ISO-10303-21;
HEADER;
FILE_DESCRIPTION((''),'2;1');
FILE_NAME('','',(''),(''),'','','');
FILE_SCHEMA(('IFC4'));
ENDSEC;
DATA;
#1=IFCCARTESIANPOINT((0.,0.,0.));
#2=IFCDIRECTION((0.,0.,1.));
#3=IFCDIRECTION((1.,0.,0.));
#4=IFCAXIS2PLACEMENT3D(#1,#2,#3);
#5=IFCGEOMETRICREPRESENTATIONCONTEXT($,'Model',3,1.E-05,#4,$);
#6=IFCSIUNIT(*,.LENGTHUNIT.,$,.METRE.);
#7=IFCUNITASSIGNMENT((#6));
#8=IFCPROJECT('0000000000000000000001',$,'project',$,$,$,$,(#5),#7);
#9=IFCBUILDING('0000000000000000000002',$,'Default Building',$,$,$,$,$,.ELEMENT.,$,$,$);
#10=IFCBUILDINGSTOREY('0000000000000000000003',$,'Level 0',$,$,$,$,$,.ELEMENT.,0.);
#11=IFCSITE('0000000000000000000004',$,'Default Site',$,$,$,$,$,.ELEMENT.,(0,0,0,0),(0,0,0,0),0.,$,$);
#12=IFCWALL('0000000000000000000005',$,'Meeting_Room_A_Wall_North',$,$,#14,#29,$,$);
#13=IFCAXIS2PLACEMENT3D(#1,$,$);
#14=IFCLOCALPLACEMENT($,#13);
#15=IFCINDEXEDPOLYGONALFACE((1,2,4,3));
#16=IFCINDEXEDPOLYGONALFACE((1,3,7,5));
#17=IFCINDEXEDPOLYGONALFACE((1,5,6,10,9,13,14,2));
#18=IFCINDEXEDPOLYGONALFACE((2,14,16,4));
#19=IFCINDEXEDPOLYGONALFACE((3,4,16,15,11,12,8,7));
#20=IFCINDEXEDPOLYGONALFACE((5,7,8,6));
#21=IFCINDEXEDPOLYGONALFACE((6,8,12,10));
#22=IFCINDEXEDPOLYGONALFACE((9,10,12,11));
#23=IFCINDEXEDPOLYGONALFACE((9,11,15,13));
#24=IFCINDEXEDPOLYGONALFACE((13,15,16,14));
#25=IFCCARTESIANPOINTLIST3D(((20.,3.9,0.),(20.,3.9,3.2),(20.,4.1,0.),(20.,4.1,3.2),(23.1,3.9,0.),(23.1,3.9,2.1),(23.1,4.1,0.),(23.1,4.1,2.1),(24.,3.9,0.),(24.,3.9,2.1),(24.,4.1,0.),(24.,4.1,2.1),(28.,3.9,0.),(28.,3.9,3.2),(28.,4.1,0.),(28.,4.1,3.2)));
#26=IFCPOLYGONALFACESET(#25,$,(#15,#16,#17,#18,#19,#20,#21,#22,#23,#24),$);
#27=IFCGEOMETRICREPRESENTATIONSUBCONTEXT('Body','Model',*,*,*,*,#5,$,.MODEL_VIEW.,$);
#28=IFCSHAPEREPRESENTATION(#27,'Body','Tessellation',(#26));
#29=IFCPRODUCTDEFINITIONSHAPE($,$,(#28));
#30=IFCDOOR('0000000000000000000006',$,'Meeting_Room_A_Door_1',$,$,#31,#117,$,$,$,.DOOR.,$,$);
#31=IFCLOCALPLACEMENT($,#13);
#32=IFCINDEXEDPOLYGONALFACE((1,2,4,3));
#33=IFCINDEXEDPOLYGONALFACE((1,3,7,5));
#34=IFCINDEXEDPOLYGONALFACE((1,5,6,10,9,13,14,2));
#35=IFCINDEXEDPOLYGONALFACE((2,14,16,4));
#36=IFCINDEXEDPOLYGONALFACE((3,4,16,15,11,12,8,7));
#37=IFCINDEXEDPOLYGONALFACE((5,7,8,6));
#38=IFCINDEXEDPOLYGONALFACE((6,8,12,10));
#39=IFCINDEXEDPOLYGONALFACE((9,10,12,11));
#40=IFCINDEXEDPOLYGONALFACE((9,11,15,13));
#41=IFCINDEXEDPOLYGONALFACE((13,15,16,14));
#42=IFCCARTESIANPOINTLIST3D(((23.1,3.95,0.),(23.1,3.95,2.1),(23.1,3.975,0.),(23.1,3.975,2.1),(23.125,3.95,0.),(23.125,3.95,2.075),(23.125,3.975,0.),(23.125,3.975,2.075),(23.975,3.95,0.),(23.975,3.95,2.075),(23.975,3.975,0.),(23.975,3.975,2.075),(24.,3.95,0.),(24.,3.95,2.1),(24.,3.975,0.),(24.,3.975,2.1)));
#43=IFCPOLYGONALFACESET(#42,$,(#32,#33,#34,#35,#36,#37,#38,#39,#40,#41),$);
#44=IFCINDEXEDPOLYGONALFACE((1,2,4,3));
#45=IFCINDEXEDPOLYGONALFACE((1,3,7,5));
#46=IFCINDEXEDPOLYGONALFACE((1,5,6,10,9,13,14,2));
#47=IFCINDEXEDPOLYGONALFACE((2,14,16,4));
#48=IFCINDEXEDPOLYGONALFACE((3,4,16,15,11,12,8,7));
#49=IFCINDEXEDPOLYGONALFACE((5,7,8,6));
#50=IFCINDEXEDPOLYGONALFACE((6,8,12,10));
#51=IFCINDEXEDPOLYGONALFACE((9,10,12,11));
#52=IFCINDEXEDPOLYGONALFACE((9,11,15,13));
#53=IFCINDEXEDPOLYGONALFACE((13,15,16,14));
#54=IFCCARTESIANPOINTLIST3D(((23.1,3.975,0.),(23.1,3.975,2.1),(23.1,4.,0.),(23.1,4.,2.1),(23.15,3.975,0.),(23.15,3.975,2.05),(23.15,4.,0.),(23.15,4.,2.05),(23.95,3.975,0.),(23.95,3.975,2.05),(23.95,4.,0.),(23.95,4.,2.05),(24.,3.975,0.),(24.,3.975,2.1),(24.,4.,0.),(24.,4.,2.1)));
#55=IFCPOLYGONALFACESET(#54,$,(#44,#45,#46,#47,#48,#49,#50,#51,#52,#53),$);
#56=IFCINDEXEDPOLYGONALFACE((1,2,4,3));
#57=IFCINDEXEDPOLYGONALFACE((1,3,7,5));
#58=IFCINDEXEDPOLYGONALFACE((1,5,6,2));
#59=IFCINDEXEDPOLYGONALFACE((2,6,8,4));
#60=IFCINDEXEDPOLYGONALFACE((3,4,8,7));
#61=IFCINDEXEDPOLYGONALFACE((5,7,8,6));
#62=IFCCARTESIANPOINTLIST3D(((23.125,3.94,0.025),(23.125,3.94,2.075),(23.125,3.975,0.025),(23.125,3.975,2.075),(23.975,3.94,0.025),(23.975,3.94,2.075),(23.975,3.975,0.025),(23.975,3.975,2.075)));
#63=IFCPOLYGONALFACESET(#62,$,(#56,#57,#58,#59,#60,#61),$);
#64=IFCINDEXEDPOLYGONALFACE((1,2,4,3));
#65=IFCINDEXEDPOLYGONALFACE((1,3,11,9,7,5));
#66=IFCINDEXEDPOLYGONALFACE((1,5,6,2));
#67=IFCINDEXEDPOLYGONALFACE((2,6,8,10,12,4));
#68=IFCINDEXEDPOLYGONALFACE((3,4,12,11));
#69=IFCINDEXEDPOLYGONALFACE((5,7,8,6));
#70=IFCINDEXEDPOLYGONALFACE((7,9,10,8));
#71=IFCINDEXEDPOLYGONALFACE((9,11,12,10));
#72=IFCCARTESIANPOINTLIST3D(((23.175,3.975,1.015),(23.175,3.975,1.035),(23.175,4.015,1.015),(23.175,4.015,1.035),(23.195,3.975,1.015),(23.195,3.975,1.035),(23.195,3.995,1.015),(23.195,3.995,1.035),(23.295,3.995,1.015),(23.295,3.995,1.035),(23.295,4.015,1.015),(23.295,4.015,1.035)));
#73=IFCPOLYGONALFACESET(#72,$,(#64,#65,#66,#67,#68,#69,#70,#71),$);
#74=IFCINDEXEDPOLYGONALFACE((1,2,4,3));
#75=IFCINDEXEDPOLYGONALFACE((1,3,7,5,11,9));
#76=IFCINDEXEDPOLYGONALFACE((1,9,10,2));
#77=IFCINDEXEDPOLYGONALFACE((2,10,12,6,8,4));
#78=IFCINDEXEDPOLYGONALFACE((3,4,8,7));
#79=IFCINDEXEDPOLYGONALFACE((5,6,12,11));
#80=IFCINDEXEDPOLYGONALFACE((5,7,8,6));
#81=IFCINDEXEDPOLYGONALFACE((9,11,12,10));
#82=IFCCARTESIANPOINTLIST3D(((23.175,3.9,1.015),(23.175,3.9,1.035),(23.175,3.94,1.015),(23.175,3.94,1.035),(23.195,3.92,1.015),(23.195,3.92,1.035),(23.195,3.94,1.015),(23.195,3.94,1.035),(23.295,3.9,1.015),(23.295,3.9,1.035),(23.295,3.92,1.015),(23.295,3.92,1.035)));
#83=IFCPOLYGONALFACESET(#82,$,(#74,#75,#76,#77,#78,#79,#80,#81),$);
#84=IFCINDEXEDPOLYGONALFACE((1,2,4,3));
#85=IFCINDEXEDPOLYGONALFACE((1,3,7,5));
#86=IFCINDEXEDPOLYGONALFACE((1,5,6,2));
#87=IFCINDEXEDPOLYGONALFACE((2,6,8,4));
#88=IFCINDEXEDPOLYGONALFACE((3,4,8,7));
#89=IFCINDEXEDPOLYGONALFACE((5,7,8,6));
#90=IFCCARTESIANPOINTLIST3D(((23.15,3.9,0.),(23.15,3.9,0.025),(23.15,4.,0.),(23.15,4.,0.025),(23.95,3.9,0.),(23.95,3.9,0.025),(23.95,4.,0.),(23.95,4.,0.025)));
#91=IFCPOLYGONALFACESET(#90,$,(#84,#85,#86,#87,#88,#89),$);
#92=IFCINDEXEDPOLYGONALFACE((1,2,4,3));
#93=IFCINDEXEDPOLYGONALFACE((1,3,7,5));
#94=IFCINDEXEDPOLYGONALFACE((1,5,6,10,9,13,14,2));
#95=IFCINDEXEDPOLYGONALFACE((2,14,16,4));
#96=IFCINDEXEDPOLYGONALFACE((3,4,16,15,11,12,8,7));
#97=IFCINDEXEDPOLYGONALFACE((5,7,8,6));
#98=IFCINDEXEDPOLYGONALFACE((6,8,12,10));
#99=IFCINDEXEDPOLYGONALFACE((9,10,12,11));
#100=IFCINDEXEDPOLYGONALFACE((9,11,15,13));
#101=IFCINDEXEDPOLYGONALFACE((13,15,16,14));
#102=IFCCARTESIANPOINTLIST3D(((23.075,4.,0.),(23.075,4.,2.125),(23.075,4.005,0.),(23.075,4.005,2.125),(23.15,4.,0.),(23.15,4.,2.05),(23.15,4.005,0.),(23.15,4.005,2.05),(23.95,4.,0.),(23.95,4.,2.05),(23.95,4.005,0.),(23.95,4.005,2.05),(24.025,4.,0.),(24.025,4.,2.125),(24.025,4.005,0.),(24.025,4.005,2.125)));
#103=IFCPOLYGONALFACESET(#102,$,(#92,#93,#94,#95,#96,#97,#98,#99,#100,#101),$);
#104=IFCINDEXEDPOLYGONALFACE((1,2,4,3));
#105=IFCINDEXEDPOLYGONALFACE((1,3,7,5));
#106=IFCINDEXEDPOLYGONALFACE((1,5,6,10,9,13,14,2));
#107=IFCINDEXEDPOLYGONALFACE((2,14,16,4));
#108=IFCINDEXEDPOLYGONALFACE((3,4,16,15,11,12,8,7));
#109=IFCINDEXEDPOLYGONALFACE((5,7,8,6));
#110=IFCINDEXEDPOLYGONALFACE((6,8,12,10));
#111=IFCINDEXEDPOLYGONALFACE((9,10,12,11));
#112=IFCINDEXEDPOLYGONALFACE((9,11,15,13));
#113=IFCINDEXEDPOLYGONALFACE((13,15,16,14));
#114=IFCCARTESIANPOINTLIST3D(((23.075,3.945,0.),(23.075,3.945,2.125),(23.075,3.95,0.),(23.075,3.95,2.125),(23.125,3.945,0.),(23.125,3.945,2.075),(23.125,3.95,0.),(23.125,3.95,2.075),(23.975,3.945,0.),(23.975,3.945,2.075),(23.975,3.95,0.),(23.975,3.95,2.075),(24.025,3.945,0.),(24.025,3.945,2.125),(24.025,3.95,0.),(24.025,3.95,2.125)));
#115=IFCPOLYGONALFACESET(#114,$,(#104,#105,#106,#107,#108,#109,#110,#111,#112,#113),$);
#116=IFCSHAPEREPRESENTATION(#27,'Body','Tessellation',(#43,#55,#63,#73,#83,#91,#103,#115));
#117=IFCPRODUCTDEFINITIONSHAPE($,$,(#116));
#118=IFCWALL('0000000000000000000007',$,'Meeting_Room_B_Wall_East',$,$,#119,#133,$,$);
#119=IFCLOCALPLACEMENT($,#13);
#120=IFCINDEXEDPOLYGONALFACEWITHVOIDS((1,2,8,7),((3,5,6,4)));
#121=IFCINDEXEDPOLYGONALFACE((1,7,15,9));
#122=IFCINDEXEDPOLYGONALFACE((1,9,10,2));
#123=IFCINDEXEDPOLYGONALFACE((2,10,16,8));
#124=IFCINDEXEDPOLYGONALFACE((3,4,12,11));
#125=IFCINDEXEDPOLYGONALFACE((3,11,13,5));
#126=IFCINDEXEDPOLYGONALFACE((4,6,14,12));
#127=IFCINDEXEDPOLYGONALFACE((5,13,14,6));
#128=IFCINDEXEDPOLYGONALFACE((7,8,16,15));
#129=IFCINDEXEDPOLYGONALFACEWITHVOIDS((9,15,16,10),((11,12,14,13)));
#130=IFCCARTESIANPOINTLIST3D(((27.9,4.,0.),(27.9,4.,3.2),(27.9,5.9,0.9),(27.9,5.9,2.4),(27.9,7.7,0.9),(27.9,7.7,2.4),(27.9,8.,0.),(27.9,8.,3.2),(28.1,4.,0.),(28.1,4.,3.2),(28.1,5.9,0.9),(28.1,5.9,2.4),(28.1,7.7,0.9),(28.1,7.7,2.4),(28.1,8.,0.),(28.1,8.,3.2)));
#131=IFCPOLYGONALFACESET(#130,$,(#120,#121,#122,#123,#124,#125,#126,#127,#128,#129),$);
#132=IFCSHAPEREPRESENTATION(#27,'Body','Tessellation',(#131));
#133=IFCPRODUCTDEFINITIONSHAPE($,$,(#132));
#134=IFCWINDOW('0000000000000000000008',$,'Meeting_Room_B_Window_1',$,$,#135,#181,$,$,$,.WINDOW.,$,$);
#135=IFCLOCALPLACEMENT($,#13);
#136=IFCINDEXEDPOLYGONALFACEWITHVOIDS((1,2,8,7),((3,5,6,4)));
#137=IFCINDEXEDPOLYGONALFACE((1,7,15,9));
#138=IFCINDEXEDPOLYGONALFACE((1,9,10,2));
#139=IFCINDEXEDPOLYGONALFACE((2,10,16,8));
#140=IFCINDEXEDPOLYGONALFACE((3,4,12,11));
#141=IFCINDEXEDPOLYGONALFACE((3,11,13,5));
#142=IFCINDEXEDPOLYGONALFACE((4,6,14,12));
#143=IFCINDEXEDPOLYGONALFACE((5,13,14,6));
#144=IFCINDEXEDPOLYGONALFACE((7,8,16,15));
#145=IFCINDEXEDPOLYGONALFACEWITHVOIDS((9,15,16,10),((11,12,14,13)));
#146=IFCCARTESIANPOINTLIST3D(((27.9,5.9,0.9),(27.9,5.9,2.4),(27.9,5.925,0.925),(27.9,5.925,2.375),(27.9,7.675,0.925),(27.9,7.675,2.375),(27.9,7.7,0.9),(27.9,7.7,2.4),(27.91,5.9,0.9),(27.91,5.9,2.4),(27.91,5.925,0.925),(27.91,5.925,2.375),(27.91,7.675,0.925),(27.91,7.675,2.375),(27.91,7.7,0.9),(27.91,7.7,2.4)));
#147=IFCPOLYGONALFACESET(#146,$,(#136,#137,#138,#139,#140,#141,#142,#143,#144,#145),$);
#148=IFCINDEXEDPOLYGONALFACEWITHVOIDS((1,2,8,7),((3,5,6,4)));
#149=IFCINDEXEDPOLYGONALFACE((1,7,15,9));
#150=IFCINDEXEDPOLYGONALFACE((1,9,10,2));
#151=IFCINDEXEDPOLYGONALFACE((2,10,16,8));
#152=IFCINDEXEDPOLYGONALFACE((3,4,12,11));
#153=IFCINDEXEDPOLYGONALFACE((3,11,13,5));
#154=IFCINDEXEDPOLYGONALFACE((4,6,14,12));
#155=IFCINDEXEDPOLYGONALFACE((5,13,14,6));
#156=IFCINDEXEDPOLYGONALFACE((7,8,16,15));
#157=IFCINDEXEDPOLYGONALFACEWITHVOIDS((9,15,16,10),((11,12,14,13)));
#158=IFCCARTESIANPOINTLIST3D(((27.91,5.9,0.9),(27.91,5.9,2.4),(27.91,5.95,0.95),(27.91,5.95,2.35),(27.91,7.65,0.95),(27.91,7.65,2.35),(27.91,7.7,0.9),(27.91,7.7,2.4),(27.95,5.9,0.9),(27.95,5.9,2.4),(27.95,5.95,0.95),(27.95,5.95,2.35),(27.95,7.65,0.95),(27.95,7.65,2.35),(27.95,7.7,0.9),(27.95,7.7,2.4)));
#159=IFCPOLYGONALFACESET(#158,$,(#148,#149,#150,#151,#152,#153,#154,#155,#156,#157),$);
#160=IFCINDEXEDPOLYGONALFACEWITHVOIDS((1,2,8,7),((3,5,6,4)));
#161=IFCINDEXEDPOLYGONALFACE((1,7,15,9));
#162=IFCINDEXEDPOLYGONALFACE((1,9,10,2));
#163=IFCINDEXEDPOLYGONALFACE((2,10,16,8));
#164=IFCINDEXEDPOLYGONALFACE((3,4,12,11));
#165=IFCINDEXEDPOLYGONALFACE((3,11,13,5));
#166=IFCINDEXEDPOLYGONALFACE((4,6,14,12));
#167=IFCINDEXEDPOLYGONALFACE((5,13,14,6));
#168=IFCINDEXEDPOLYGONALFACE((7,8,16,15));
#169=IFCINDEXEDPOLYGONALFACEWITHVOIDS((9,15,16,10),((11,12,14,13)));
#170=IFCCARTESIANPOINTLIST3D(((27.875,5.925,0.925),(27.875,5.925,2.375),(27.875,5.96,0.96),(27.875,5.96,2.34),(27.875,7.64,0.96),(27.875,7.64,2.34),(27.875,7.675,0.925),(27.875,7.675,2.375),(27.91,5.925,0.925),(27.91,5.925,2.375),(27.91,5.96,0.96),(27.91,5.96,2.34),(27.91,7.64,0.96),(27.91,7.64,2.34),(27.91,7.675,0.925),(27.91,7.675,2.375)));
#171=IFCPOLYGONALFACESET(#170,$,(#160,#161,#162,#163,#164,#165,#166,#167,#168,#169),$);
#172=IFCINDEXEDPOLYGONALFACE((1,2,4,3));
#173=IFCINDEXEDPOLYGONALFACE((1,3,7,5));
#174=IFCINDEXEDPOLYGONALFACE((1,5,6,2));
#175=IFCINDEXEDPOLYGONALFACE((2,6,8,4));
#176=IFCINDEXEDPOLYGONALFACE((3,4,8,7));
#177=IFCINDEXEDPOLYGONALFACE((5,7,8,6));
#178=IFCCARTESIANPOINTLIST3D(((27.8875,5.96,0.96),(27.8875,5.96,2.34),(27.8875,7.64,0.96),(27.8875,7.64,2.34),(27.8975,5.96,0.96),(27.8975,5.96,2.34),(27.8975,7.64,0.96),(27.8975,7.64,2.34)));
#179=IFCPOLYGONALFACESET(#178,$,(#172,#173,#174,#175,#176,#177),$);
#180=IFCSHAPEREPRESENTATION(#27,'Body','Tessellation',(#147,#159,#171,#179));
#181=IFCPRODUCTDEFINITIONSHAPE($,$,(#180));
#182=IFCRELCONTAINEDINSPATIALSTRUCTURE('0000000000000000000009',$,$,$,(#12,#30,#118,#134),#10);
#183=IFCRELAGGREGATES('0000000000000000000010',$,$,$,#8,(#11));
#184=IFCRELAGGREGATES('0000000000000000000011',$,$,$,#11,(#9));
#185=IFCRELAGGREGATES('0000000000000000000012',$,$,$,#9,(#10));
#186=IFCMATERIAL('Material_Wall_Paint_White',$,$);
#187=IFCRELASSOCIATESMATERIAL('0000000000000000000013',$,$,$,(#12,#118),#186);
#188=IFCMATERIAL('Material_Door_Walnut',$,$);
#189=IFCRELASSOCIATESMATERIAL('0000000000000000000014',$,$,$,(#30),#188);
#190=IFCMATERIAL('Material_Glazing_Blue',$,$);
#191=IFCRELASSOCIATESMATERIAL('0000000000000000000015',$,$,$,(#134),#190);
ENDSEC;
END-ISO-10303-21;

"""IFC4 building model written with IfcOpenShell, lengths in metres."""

from ifc_helpers import new_model, si_unit, frame, origin_with_axes, place, context, subcontext, project, spatial, line, indexed_curve, outline, extrude, material, element, fill, save


model = new_model("IFC4")

# Units and contexts
model_context = context("Model", 3, precision=1e-05, world=origin_with_axes())
body_context = subcontext(model_context, "Body", "Model", "MODEL_VIEW")
ifc_project = project(units=[si_unit("LENGTHUNIT", "METRE")], contexts=[model_context])

# Site, building, storey
site = spatial("IfcSite", under=ifc_project, Name="Default Site", CompositionType="ELEMENT", RefLatitude=(0, 0, 0, 0), RefLongitude=(0, 0, 0, 0), RefElevation=0.0)
building = spatial("IfcBuilding", under=site, Name="Default Building", CompositionType="ELEMENT")
storey = spatial("IfcBuildingStorey", under=building, Name="Level 0", CompositionType="ELEMENT", Elevation=0.0)

# Shared definitions
ifc_material_1 = material(Name="Material_Wall_Paint_White")
ifc_material_2 = material(Name="Material_Glazing_Blue")

# Wall, opening, door
wall_1_placement = place(None, frame((28.0, 4.0, 0.0), z_axis=(0.0, 0.0, 1.0), x_axis=(-1.0, 0.0, 0.0)))
wall_1 = element("IfcWall", 1, at=wall_1_placement, inside=storey, material=ifc_material_1, Name="Meeting_Room_A_Wall_North", context=body_context, shape_type="SweptSolid", body=[
    extrude(outline(indexed_curve([(0.0, 0.0), (0.0, 0.2), (8.0, 0.2), (8.0, 0.0), (0.0, 0.0)], self_intersect=False)), frame((0.0, -0.1, 0.0), z_axis=(0.0, 0.0, 1.0), x_axis=(1.0, 0.0, 0.0)), (0.0, 0.0, 1.0), 3.2),
])
opening_1_placement = place(wall_1_placement, frame((4.0, -0.5, 0.0), z_axis=(0.0, 0.0, 1.0), x_axis=(1.0, 0.0, 0.0)))
opening_1 = element("IfcOpeningElement", 2, at=opening_1_placement, inside=storey, cuts=wall_1, PredefinedType="OPENING", context=body_context, shape_type="SweptSolid", body=[
    extrude(outline(indexed_curve([(0.0, 0.0), (0.0, 1.0), (0.9, 1.0), (0.9, 0.0), (0.0, 0.0)], self_intersect=False)), origin_with_axes(), (0.0, 0.0, 1.0), 2.1),
])
ifc_material_3 = material(Name="Material_Door_Walnut")
door_1_placement = place(None, frame((24.0, 4.0, 0.0), z_axis=(0.0, 0.0, 1.0), x_axis=(-1.0, 0.0, 0.0)))
door_1 = element("IfcDoor", 3, at=door_1_placement, inside=storey, material=ifc_material_3, Name="Meeting_Room_A_Door_1", PredefinedType="DOOR", context=body_context, shape_type="SweptSolid", body=[
    extrude(outline(indexed_curve([(0.0, 0.0), (0.0, 2.1), (0.9, 2.1), (0.9, 0.0), (0.875, 0.0), (0.875, 2.075), (0.025, 2.075), (0.025, 0.0)], segments=[line(1, 2, 3, 4, 5, 6, 7, 8, 1)])), frame((0.0, 0.025, 0.0), z_axis=(0.0, -1.0, 0.0), x_axis=(1.0, 0.0, 0.0)), (0.0, 0.0, -1.0), 0.025),
    extrude(outline(indexed_curve([(0.0, 0.0), (0.0, 2.1), (0.9, 2.1), (0.9, 0.0), (0.85, 0.0), (0.85, 2.05), (0.05, 2.05), (0.05, 0.0)], segments=[line(1, 2, 3, 4, 5, 6, 7, 8, 1)])), frame((0.0, 0.0, 0.0), z_axis=(0.0, -1.0, 0.0), x_axis=(1.0, 0.0, 0.0)), (0.0, 0.0, -1.0), 0.025),
    extrude(outline(indexed_curve([(0.0, 0.0), (0.85, 0.0), (0.85, 0.035), (0.0, 0.035)], segments=[line(1, 2, 3, 4, 1)])), frame((0.025, 0.025, 0.025), z_axis=(0.0, 0.0, 1.0), x_axis=(1.0, 0.0, 0.0)), (0.0, 0.0, 1.0), 2.05),
    extrude(outline(indexed_curve([(0.0, 0.0), (0.0, -0.04), (-0.12, -0.04), (-0.12, -0.02), (-0.02, -0.02), (-0.02, 0.0)], segments=[line(1, 2, 3, 4, 5, 6, 1)])), frame((0.825, 0.025, 1.015), z_axis=(0.0, 0.0, 1.0), x_axis=(1.0, 0.0, 0.0)), (0.0, 0.0, 1.0), 0.02),
    extrude(outline(indexed_curve([(0.0, 0.0), (0.0, 0.04), (-0.12, 0.04), (-0.12, 0.02), (-0.02, 0.02), (-0.02, 0.0)], segments=[line(1, 2, 3, 4, 5, 6, 1)])), frame((0.825, 0.06, 1.015), z_axis=(0.0, 0.0, 1.0), x_axis=(1.0, 0.0, 0.0)), (0.0, 0.0, 1.0), 0.02),
    extrude(outline(indexed_curve([(0.0, 0.0), (0.8, 0.0), (0.8, 0.1), (0.0, 0.1)], segments=[line(1, 2, 3, 4, 1)])), frame((0.05, 0.0, 0.0), z_axis=(0.0, 0.0, 1.0), x_axis=(1.0, 0.0, 0.0)), (0.0, 0.0, 1.0), 0.025),
    extrude(outline(indexed_curve([(0.0, 0.0), (0.0, 2.125), (0.95, 2.125), (0.95, 0.0), (0.875, 0.0), (0.875, 2.05), (0.075, 2.05), (0.075, 0.0)], segments=[line(1, 2, 3, 4, 5, 6, 7, 8, 1)])), frame((-0.025, -0.005, 0.0), z_axis=(0.0, -1.0, 0.0), x_axis=(1.0, 0.0, 0.0)), (0.0, 0.0, -1.0), 0.005),
    extrude(outline(indexed_curve([(0.0, 0.0), (0.0, 2.125), (0.95, 2.125), (0.95, 0.0), (0.9, 0.0), (0.9, 2.075), (0.05, 2.075), (0.05, 0.0)], segments=[line(1, 2, 3, 4, 5, 6, 7, 8, 1)])), frame((-0.025, 0.05, 0.0), z_axis=(0.0, -1.0, 0.0), x_axis=(1.0, 0.0, 0.0)), (0.0, 0.0, -1.0), 0.005),
])
fill(opening_1, door_1)

# Wall, opening, window
wall_2_placement = place(None, frame((28.0, 4.0, 0.0), z_axis=(0.0, 0.0, 1.0), x_axis=(0.0, 1.0, 0.0)))
wall_2 = element("IfcWall", 4, at=wall_2_placement, inside=storey, material=ifc_material_1, Name="Meeting_Room_B_Wall_East", context=body_context, shape_type="SweptSolid", body=[
    extrude(outline(indexed_curve([(0.0, 0.0), (0.0, 0.2), (4.0, 0.2), (4.0, 0.0), (0.0, 0.0)], self_intersect=False)), frame((0.0, -0.1, 0.0), z_axis=(0.0, 0.0, 1.0), x_axis=(1.0, 0.0, 0.0)), (0.0, 0.0, 1.0), 3.2),
])
opening_2_placement = place(wall_2_placement, frame((1.9, -0.5, 0.9), z_axis=(0.0, 0.0, 1.0), x_axis=(1.0, 0.0, 0.0)))
opening_2 = element("IfcOpeningElement", 5, at=opening_2_placement, inside=storey, cuts=wall_2, PredefinedType="OPENING", context=body_context, shape_type="SweptSolid", body=[
    extrude(outline(indexed_curve([(0.0, 0.0), (0.0, 1.0), (1.8, 1.0), (1.8, 0.0), (0.0, 0.0)], self_intersect=False)), origin_with_axes(), (0.0, 0.0, 1.0), 1.5),
])
window_1_placement = place(None, frame((28.0, 5.9, 0.9), z_axis=(0.0, 0.0, 1.0), x_axis=(0.0, 1.0, 0.0)))
window_1 = element("IfcWindow", 6, at=window_1_placement, inside=storey, material=ifc_material_2, Name="Meeting_Room_B_Window_1", PredefinedType="WINDOW", context=body_context, shape_type="SweptSolid", body=[
    extrude(outline(indexed_curve([(0.0, 0.0), (1.8, 0.0), (1.8, 1.5), (0.0, 1.5)], segments=[line(1, 2, 3, 4, 1)]), holes=[indexed_curve([(0.025, 0.025), (1.775, 0.025), (1.775, 1.475), (0.025, 1.475)], segments=[line(1, 2, 3, 4, 1)])]), frame((0.0, 0.09, 0.0), z_axis=(0.0, -1.0, 0.0), x_axis=(1.0, 0.0, 0.0)), (0.0, 0.0, -1.0), 0.01),
    extrude(outline(indexed_curve([(0.0, 0.0), (1.8, 0.0), (1.8, 1.5), (0.0, 1.5)], segments=[line(1, 2, 3, 4, 1)]), holes=[indexed_curve([(0.05, 0.05), (1.75, 0.05), (1.75, 1.45), (0.05, 1.45)], segments=[line(1, 2, 3, 4, 1)])]), frame((0.0, 0.05, 0.0), z_axis=(0.0, -1.0, 0.0), x_axis=(1.0, 0.0, 0.0)), (0.0, 0.0, -1.0), 0.04),
    extrude(outline(indexed_curve([(0.0, 0.0), (1.75, 0.0), (1.75, 1.45), (0.0, 1.45)], segments=[line(1, 2, 3, 4, 1)]), holes=[indexed_curve([(0.035, 0.035), (1.715, 0.035), (1.715, 1.415), (0.035, 1.415)], segments=[line(1, 2, 3, 4, 1)])]), frame((0.025, 0.09, 0.025), z_axis=(0.0, -1.0, 0.0), x_axis=(1.0, 0.0, 0.0)), (0.0, 0.0, -1.0), 0.035),
    extrude(outline(indexed_curve([(0.035, 0.035), (1.715, 0.035), (1.715, 1.415), (0.035, 1.415)], segments=[line(1, 2, 3, 4, 1)])), frame((0.025, 0.1025, 0.025), z_axis=(0.0, -1.0, 0.0), x_axis=(1.0, 0.0, 0.0)), (0.0, 0.0, -1.0), 0.01),
])
fill(opening_2, window_1)

save(model, "model.ifc")
